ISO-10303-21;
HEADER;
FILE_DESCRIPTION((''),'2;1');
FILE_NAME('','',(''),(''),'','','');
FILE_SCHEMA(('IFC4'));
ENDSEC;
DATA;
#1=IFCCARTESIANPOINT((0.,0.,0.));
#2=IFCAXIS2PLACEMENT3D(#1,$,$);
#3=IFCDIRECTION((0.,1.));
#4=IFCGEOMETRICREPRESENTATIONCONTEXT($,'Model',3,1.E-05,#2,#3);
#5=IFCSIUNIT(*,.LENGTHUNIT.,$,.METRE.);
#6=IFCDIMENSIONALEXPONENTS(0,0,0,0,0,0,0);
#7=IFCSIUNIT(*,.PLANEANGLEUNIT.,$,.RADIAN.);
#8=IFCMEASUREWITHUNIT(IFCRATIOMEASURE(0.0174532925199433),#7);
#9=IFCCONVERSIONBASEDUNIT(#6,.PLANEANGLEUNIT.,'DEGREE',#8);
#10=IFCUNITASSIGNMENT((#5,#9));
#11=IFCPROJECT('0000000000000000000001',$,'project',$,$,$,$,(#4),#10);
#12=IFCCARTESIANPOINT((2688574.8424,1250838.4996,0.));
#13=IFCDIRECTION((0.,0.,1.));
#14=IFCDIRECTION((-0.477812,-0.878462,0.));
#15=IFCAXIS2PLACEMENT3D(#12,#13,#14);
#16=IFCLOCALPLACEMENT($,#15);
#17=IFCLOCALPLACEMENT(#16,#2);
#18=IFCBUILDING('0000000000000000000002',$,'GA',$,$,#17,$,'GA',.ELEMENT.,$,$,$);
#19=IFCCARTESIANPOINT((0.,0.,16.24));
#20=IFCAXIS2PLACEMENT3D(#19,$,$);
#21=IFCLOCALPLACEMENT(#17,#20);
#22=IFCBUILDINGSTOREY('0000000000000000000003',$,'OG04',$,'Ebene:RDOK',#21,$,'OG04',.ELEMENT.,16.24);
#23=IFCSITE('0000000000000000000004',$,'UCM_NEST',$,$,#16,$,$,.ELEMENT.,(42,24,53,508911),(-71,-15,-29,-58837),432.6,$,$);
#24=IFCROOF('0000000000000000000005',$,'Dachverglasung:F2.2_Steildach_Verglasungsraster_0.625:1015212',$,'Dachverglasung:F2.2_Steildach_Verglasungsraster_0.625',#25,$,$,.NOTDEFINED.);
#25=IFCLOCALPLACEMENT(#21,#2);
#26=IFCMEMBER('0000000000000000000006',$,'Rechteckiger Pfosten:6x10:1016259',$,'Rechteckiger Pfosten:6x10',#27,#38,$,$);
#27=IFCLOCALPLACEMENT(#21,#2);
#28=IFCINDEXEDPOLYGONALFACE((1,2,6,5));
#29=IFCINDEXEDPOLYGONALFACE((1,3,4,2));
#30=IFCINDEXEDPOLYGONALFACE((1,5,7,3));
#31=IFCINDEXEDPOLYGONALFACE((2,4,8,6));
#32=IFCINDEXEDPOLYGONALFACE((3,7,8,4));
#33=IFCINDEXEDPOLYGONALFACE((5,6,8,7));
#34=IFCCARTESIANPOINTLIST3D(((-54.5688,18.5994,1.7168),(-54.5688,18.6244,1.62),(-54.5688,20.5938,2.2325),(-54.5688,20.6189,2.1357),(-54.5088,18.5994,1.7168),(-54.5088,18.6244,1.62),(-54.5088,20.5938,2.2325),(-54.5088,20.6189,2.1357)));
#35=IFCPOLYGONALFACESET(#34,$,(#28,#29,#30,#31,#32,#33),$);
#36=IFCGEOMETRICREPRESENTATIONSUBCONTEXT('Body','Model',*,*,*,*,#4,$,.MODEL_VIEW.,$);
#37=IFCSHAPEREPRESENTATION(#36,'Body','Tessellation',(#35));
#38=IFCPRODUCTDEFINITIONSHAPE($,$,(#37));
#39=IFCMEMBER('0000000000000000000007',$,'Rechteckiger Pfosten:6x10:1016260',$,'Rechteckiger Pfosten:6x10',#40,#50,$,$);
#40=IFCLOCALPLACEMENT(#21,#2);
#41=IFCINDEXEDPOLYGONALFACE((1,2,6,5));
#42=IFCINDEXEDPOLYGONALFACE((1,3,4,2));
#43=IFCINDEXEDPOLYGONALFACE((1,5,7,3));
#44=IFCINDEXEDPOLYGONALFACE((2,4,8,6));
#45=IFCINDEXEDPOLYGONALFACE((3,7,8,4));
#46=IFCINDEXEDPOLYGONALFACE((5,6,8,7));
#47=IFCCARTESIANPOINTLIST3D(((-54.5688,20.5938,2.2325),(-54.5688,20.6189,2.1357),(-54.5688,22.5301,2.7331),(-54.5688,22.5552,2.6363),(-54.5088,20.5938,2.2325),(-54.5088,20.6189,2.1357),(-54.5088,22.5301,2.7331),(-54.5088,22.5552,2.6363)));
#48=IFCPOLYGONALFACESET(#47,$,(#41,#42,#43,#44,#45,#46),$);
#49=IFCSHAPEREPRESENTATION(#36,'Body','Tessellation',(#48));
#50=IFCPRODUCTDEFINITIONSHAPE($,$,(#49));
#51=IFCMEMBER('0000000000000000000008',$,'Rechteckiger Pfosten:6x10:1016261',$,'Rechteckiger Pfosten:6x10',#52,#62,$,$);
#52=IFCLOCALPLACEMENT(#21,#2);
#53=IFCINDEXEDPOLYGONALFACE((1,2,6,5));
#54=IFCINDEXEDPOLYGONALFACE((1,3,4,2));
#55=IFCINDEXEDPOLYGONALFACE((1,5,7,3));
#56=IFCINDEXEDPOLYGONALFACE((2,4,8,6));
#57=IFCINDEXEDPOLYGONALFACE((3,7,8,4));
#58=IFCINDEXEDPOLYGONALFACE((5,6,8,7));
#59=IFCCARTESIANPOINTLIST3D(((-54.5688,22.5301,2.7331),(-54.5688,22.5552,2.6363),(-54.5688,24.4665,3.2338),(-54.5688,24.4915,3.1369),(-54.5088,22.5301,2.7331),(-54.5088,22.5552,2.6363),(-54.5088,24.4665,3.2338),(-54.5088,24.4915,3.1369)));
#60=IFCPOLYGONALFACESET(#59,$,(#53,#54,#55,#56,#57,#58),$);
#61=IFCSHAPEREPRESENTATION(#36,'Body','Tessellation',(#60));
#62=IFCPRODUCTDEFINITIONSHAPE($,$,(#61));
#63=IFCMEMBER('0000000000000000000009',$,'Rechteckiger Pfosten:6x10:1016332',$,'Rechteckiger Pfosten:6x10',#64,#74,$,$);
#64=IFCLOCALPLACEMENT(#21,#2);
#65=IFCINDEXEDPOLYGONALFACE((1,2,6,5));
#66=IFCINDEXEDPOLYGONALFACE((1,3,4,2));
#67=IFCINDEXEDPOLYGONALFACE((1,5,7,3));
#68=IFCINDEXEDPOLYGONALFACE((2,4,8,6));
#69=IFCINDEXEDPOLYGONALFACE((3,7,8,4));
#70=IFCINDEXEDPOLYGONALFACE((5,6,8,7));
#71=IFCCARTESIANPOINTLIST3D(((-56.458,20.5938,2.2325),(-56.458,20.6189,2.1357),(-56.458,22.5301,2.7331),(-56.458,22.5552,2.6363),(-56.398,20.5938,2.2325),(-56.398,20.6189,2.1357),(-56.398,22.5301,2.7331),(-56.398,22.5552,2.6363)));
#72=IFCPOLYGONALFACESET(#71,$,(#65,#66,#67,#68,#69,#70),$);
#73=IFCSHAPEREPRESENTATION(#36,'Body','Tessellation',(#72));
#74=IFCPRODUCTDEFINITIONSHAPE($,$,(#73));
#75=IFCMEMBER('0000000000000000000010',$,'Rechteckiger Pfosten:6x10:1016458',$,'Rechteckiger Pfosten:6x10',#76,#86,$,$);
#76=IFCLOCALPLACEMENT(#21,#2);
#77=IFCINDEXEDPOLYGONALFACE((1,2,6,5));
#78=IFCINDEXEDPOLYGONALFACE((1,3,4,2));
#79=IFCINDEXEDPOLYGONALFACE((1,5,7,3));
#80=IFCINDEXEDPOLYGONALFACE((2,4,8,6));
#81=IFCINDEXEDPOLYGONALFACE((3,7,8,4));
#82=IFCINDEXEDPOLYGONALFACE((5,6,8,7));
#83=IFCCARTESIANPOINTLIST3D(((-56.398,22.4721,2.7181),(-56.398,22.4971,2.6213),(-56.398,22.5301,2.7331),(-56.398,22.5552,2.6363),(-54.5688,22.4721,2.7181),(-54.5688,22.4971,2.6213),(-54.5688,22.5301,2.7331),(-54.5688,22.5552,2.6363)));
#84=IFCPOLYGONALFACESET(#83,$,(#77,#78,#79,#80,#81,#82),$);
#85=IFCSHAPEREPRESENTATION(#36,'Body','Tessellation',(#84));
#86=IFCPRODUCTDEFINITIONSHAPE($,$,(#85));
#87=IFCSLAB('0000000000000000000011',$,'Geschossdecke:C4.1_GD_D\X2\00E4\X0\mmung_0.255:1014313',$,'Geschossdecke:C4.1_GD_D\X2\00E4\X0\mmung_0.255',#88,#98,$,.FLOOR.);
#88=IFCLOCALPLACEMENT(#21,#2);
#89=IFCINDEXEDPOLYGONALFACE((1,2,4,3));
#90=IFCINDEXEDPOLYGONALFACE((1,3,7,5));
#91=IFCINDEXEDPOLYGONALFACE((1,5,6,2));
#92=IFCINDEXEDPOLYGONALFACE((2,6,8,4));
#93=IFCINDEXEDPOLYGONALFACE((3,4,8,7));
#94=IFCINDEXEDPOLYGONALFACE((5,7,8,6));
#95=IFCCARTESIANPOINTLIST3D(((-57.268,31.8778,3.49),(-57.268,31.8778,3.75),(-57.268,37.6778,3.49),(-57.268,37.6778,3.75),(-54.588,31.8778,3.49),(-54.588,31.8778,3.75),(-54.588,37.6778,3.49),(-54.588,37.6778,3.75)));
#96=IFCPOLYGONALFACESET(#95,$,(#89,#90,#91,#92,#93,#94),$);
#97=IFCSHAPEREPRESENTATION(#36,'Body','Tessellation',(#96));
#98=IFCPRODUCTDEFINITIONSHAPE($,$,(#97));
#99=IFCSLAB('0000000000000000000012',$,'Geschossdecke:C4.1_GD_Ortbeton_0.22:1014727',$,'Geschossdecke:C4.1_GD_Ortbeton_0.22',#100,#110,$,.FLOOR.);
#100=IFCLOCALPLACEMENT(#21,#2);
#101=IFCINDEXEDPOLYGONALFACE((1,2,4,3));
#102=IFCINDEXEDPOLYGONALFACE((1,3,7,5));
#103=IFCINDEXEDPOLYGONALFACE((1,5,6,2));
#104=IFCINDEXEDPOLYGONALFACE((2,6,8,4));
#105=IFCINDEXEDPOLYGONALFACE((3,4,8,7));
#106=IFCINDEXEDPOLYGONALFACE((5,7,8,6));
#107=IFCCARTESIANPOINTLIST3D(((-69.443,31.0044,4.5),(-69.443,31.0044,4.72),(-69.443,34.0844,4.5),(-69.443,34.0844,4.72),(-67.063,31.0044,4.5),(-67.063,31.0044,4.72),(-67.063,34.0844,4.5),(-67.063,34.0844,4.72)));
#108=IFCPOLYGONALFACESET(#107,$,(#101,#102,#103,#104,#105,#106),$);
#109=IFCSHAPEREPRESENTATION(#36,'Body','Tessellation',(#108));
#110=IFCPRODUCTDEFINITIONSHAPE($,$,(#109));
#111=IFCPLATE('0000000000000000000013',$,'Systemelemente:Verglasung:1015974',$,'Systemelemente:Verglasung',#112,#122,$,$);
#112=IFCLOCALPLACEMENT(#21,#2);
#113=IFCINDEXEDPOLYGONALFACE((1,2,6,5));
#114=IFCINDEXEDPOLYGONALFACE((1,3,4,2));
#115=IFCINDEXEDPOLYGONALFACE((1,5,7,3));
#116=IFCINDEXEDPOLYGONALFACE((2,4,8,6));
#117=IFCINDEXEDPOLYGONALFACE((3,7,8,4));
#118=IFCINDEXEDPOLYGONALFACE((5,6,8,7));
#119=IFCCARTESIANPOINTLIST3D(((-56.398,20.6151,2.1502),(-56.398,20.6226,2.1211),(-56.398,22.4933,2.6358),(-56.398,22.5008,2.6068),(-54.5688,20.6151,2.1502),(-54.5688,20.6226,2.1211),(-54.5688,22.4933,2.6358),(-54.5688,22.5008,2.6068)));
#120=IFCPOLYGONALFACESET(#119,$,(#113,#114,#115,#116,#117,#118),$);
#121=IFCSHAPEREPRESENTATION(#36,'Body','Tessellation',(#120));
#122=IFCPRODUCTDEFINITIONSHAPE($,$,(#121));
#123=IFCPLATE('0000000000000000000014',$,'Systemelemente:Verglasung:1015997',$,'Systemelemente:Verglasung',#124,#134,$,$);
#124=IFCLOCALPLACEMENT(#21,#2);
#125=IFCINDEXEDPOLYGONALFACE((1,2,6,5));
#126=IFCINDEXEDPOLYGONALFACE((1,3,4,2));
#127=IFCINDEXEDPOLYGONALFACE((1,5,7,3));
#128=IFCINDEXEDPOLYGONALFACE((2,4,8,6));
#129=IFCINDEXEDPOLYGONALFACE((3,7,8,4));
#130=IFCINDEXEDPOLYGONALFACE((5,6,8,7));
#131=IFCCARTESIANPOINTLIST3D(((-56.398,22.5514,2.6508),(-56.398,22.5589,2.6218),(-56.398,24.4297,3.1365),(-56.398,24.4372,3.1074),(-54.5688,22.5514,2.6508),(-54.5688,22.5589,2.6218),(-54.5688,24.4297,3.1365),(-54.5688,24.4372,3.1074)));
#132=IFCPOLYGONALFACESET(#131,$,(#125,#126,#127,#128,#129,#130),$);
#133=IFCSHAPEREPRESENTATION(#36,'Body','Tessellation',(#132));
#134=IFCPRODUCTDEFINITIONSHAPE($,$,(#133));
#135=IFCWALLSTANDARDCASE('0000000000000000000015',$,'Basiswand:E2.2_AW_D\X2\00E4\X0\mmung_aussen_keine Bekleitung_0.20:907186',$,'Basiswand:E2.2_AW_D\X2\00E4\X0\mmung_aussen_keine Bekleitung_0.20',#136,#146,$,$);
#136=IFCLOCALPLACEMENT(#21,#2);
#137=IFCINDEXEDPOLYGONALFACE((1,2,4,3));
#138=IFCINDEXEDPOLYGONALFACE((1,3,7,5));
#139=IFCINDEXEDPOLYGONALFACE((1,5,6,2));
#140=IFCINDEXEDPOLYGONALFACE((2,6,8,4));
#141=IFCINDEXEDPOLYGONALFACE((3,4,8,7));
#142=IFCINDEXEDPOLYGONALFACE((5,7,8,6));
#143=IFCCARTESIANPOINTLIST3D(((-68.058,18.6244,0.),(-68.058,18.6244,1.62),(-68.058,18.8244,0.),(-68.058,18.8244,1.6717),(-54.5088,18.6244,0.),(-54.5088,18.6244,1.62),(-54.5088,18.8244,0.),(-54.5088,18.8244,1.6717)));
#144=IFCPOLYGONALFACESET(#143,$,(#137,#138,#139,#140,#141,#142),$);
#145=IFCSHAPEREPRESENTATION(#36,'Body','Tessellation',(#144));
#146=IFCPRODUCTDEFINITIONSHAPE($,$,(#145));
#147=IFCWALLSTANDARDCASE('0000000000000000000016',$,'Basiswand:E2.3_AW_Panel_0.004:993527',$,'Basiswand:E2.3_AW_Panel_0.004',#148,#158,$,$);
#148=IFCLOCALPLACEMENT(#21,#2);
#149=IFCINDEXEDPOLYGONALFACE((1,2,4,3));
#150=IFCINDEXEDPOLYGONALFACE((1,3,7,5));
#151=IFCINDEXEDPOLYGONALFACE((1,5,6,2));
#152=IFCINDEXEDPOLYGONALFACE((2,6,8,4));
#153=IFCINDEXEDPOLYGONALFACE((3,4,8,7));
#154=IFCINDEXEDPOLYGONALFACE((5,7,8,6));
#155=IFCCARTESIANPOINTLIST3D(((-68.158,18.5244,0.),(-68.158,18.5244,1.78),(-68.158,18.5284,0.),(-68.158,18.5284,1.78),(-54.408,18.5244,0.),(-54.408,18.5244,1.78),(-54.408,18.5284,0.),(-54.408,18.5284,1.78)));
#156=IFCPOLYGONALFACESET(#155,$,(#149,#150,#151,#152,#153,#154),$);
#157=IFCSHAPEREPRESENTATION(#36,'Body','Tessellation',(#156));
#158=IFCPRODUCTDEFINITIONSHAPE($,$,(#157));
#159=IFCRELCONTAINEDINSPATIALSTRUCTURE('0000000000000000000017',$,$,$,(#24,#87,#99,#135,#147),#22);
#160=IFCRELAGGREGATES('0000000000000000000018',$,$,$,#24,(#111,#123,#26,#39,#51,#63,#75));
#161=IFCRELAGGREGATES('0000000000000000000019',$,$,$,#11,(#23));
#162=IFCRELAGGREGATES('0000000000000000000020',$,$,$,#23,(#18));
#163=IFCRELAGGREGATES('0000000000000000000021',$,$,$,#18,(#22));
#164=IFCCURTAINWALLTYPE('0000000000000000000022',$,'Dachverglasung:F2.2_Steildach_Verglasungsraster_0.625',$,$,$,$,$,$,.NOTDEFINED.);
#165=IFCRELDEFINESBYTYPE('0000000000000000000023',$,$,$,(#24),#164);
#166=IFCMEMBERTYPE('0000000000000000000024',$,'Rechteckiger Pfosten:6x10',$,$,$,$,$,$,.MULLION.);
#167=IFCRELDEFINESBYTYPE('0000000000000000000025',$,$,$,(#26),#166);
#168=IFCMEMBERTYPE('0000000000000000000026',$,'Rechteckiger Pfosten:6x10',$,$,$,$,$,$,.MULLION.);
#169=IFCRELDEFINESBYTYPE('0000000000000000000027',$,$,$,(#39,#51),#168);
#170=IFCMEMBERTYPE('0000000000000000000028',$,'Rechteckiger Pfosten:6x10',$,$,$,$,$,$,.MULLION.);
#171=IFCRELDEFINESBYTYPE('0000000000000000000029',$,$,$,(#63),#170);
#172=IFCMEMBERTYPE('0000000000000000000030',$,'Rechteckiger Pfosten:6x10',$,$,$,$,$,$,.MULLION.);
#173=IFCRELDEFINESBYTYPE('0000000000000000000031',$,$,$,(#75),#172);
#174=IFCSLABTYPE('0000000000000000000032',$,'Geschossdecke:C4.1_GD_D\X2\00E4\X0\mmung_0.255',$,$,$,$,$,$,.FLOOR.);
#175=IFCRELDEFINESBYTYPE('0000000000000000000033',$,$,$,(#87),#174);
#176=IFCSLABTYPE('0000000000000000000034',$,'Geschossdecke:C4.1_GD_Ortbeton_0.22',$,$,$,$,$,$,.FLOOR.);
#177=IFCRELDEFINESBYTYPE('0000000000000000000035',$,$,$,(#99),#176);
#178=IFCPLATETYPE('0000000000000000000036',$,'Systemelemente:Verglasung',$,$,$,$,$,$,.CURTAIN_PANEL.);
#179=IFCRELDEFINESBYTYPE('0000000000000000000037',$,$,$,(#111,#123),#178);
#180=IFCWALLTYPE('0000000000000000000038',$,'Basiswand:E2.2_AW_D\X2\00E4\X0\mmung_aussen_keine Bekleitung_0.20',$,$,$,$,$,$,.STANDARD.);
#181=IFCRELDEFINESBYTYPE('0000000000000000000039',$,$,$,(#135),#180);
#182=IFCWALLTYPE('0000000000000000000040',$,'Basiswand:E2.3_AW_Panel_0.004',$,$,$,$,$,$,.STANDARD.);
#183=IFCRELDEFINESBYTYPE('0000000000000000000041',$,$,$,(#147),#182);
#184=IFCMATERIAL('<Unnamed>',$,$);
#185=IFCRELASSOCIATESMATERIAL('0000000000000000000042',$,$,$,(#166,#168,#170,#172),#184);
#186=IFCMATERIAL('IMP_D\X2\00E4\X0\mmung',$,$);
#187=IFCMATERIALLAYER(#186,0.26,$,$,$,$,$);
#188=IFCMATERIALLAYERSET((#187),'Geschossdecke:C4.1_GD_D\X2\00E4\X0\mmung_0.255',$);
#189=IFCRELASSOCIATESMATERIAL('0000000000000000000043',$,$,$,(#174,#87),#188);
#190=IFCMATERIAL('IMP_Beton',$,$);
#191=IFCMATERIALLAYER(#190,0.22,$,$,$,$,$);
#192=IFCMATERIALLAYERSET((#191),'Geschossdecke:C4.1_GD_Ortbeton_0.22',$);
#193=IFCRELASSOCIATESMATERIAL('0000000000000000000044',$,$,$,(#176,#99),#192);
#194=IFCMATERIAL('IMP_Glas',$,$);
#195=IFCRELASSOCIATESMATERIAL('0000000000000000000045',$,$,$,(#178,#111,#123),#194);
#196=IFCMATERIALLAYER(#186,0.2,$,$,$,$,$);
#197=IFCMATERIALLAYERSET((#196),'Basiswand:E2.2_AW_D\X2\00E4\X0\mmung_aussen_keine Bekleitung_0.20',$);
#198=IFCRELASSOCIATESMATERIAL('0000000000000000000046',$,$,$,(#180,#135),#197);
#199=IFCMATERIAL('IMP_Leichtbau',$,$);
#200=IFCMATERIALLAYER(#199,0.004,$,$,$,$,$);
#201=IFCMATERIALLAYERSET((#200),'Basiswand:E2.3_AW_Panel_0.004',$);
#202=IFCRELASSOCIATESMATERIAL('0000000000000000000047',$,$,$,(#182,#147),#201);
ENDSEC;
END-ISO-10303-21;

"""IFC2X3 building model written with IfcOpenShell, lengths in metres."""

from ifc_helpers import new_model, entity, si_unit, converted_unit, direction, frame, frame_2d, origin, origin_2d_with_axis, place, context, subcontext, project, spatial, polyline, rectangle, extrude, clip, bounded_halfspace, source, transform, mapped, material, layer, layer_set, layer_usage, type_object, type_shapes, element, aggregate, save


model = new_model("IFC2X3")

# Units and contexts
model_context = context("Model", 3, precision=1e-05, world=origin(), true_north=direction((0.0, 1.0)))
body_context = subcontext(model_context, "Body", "Model", "MODEL_VIEW")
ifc_project = project(units=[si_unit("LENGTHUNIT", "METRE"), converted_unit("PLANEANGLEUNIT", "DEGREE", entity("IfcRatioMeasure", 0.0174532925199433), si_unit("PLANEANGLEUNIT", "RADIAN"), dimensions=[0, 0, 0, 0, 0, 0, 0])], contexts=[model_context])

# Site, building, storey
site_placement = place(None, frame((2688574.8424, 1250838.4996, 0.0), z_axis=(0.0, 0.0, 1.0), x_axis=(-0.477812, -0.878462, 0.0)))
site = spatial("IfcSite", under=ifc_project, at=site_placement, Name="UCM_NEST", CompositionType="ELEMENT", RefLatitude=(42, 24, 53, 508911), RefLongitude=(-71, -15, -29, -58837), RefElevation=432.6)
building_placement = place(site_placement, origin())
building = spatial("IfcBuilding", under=site, at=building_placement, Name="GA", LongName="GA", CompositionType="ELEMENT")
storey_placement = place(building_placement, frame((0.0, 0.0, 16.24)))
storey = spatial("IfcBuildingStorey", under=building, at=storey_placement, Name="OG04", ObjectType="Ebene:RDOK", LongName="OG04", CompositionType="ELEMENT", Elevation=16.24)

# Roof, members
curtain_wall_type = type_object("IfcCurtainWallType", Name="Dachverglasung:F2.2_Steildach_Verglasungsraster_0.625", PredefinedType="NOTDEFINED")
roof_placement = place(storey_placement, frame((0.0, 0.0, -16.24)))
roof = element("IfcRoof", 1, at=roof_placement, inside=storey, type_object=curtain_wall_type, Name="Dachverglasung:F2.2_Steildach_Verglasungsraster_0.625:1015212", ObjectType="Dachverglasung:F2.2_Steildach_Verglasungsraster_0.625", ShapeType="NOTDEFINED")
ifc_material_1 = material(Name="<Unnamed>")
member_type_1 = type_object("IfcMemberType", Name="Rechteckiger Pfosten:6x10", PredefinedType="MULLION", material=ifc_material_1)
shared_shape_1 = source(origin(), body_context, "Body", "SweptSolid", [
    extrude(rectangle(XDim=0.1, YDim=0.06, at=frame_2d((0.0, 0.0), x_axis=(1.0, 0.0))), frame((-0.03, -0.05, -2.06), z_axis=(0.0, 0.0, 1.0), x_axis=(0.0, -1.0, 0.0)), (0.0, 0.0, 1.0), 2.06),
])
type_shapes(member_type_1, [shared_shape_1])
member_1_placement = place(roof_placement, frame((-54.5088, 20.6189, 18.3757), z_axis=(0.0, 0.968163, 0.250322), x_axis=(1.0, 0.0, 0.0)))
member_1 = element("IfcMember", 2, at=member_1_placement, type_object=member_type_1, Name="Rechteckiger Pfosten:6x10:1016259", ObjectType="Rechteckiger Pfosten:6x10", context=body_context, shape_type="MappedRepresentation", body=[
    mapped(shared_shape_1, transform((0.0, 0.0, 0.0), scale=1.0)),
])
member_type_2 = type_object("IfcMemberType", Name="Rechteckiger Pfosten:6x10", PredefinedType="MULLION", material=ifc_material_1)
shared_shape_2 = source(origin(), body_context, "Body", "SweptSolid", [
    extrude(rectangle(XDim=0.1, YDim=0.06, at=origin_2d_with_axis()), frame((-0.03, -0.05, -2.0), z_axis=(0.0, 0.0, 1.0), x_axis=(0.0, -1.0, 0.0)), (0.0, 0.0, 1.0), 2.0),
])
type_shapes(member_type_2, [shared_shape_2])
member_2_placement = place(roof_placement, frame((-54.5088, 22.5552, 18.8763), z_axis=(0.0, 0.968163, 0.250322), x_axis=(1.0, 0.0, 0.0)))
member_2 = element("IfcMember", 3, at=member_2_placement, type_object=member_type_2, Name="Rechteckiger Pfosten:6x10:1016260", ObjectType="Rechteckiger Pfosten:6x10", context=body_context, shape_type="MappedRepresentation", body=[
    mapped(shared_shape_2, transform((0.0, 0.0, 0.0), scale=1.0)),
])
member_3_placement = place(roof_placement, frame((-54.5088, 24.4915, 19.3769), z_axis=(0.0, 0.968163, 0.250322), x_axis=(1.0, 0.0, 0.0)))
member_3 = element("IfcMember", 4, at=member_3_placement, type_object=member_type_2, Name="Rechteckiger Pfosten:6x10:1016261", ObjectType="Rechteckiger Pfosten:6x10", context=body_context, shape_type="MappedRepresentation", body=[
    mapped(shared_shape_2, transform((0.0, 0.0, 0.0), scale=1.0)),
])
member_type_3 = type_object("IfcMemberType", Name="Rechteckiger Pfosten:6x10", PredefinedType="MULLION", material=ifc_material_1)
shared_shape_3 = source(origin(), body_context, "Body", "SweptSolid", [
    extrude(rectangle(XDim=0.1, YDim=0.06, at=origin_2d_with_axis()), frame((-0.03, -0.05, -2.0), z_axis=(0.0, 0.0, 1.0), x_axis=(0.0, -1.0, 0.0)), (0.0, 0.0, 1.0), 2.0),
])
type_shapes(member_type_3, [shared_shape_3])
member_4_placement = place(roof_placement, frame((-56.398, 22.5552, 18.8763), z_axis=(0.0, 0.968163, 0.250322), x_axis=(1.0, 0.0, 0.0)))
member_4 = element("IfcMember", 5, at=member_4_placement, type_object=member_type_3, Name="Rechteckiger Pfosten:6x10:1016332", ObjectType="Rechteckiger Pfosten:6x10", context=body_context, shape_type="MappedRepresentation", body=[
    mapped(shared_shape_3, transform((0.0, 0.0, 0.0), scale=1.0)),
])
member_type_4 = type_object("IfcMemberType", Name="Rechteckiger Pfosten:6x10", PredefinedType="MULLION", material=ifc_material_1)
shared_shape_4 = source(origin(), body_context, "Body", "SweptSolid", [
    extrude(rectangle(XDim=0.1, YDim=0.06, at=origin_2d_with_axis()), frame((-0.03, -0.05, -1.8292), z_axis=(0.0, 0.0, 1.0), x_axis=(0.0, -1.0, 0.0)), (0.0, 0.0, 1.0), 1.8292),
])
type_shapes(member_type_4, [shared_shape_4])
member_5_placement = place(roof_placement, frame((-56.398, 22.5552, 18.8763), z_axis=(-1.0, 0.0, 0.0), x_axis=(0.0, 0.968163, 0.250322)))
member_5 = element("IfcMember", 6, at=member_5_placement, type_object=member_type_4, Name="Rechteckiger Pfosten:6x10:1016458", ObjectType="Rechteckiger Pfosten:6x10", context=body_context, shape_type="MappedRepresentation", body=[
    mapped(shared_shape_4, transform((0.0, 0.0, 0.0), scale=1.0)),
])

# Slabs
ifc_material_2 = material(Name="IMP_Beton")
ifc_material_3 = material(Name="IMP_Dämmung")
ifc_layer_1 = layer(ifc_material_3, 0.26)
ifc_layer_set_1 = layer_set([ifc_layer_1], Name="Geschossdecke:C4.1_GD_Dämmung_0.255")
ifc_layer_usage_1 = layer_usage(ifc_layer_set_1, "AXIS3", "POSITIVE", 0.0)
slab_type_1 = type_object("IfcSlabType", Name="Geschossdecke:C4.1_GD_Dämmung_0.255", PredefinedType="FLOOR", material=ifc_layer_set_1)
slab_1_placement = place(storey_placement, origin())
element("IfcSlab", 7, at=slab_1_placement, inside=storey, type_object=slab_type_1, material=ifc_layer_usage_1, Name="Geschossdecke:C4.1_GD_Dämmung_0.255:1014313", ObjectType="Geschossdecke:C4.1_GD_Dämmung_0.255", PredefinedType="FLOOR", context=body_context, shape_type="SweptSolid", body=[
    extrude(rectangle(XDim=5.8, YDim=2.68, at=frame_2d((0.0, 0.0), x_axis=(1.0, 0.0))), frame((-55.928, 34.7778, 3.75), z_axis=(0.0, 0.0, -1.0), x_axis=(0.0, 1.0, 0.0)), (0.0, 0.0, 1.0), 0.26),
])
ifc_layer_2 = layer(ifc_material_2, 0.22)
ifc_layer_set_2 = layer_set([ifc_layer_2], Name="Geschossdecke:C4.1_GD_Ortbeton_0.22")
ifc_layer_usage_2 = layer_usage(ifc_layer_set_2, "AXIS3", "POSITIVE", 0.0)
slab_type_2 = type_object("IfcSlabType", Name="Geschossdecke:C4.1_GD_Ortbeton_0.22", PredefinedType="FLOOR", material=ifc_layer_set_2)
slab_2_placement = place(storey_placement, origin())
element("IfcSlab", 8, at=slab_2_placement, inside=storey, type_object=slab_type_2, material=ifc_layer_usage_2, Name="Geschossdecke:C4.1_GD_Ortbeton_0.22:1014727", ObjectType="Geschossdecke:C4.1_GD_Ortbeton_0.22", PredefinedType="FLOOR", context=body_context, shape_type="SweptSolid", body=[
    extrude(rectangle(XDim=3.08, YDim=2.38, at=origin_2d_with_axis()), frame((-68.253, 32.5444, 4.72), z_axis=(0.0, 0.0, -1.0), x_axis=(0.0, 1.0, 0.0)), (0.0, 0.0, 1.0), 0.22),
])

# Plates
ifc_material_4 = material(Name="IMP_Glas")
plate_type = type_object("IfcPlateType", Name="Systemelemente:Verglasung", PredefinedType="CURTAIN_PANEL", material=ifc_material_4)
shared_shape_5 = source(origin(), body_context, "Body", "SweptSolid", [
    extrude(rectangle(XDim=0.03, YDim=1.8292, at=origin_2d_with_axis()), frame((0.0, 0.0, 0.0), z_axis=(0.0, 0.0, 1.0), x_axis=(0.0, 1.0, 0.0)), (0.0, 0.0, 1.0), 1.94),
])
type_shapes(plate_type, [shared_shape_5])
plate_1_placement = place(roof_placement, frame((-55.4834, 20.6189, 18.3757), z_axis=(0.0, 0.968163, 0.250322), x_axis=(1.0, 0.0, 0.0)))
plate_1 = element("IfcPlate", 9, at=plate_1_placement, type_object=plate_type, material=ifc_material_4, Name="Systemelemente:Verglasung:1015974", ObjectType="Systemelemente:Verglasung", context=body_context, shape_type="MappedRepresentation", body=[
    mapped(shared_shape_5, transform((0.0, 0.0, 0.0), scale=1.0)),
])
plate_2_placement = place(roof_placement, frame((-55.4834, 22.5552, 18.8763), z_axis=(0.0, 0.968163, 0.250322), x_axis=(1.0, 0.0, 0.0)))
plate_2 = element("IfcPlate", 10, at=plate_2_placement, type_object=plate_type, material=ifc_material_4, Name="Systemelemente:Verglasung:1015997", ObjectType="Systemelemente:Verglasung", context=body_context, shape_type="MappedRepresentation", body=[
    mapped(shared_shape_5, transform((0.0, 0.0, 0.0), scale=1.0)),
])
aggregate(roof, [plate_1, plate_2, member_1, member_2, member_3, member_4, member_5])

# Walls
ifc_layer_3 = layer(ifc_material_3, 0.2)
ifc_layer_set_3 = layer_set([ifc_layer_3], Name="Basiswand:E2.2_AW_Dämmung_aussen_keine Bekleitung_0.20")
ifc_layer_usage_3 = layer_usage(ifc_layer_set_3, "AXIS2", "NEGATIVE", 0.1)
wall_type_1 = type_object("IfcWallType", Name="Basiswand:E2.2_AW_Dämmung_aussen_keine Bekleitung_0.20", PredefinedType="STANDARD", material=ifc_layer_set_3)
wall_1_placement = place(storey_placement, frame((-54.5088, 18.7244, 0.0), z_axis=(0.0, 0.0, 1.0), x_axis=(-1.0, 0.0, 0.0)))
element("IfcWallStandardCase", 11, at=wall_1_placement, inside=storey, type_object=wall_type_1, material=ifc_layer_usage_3, Name="Basiswand:E2.2_AW_Dämmung_aussen_keine Bekleitung_0.20:907186", ObjectType="Basiswand:E2.2_AW_Dämmung_aussen_keine Bekleitung_0.20", context=body_context, shape_type="Clipping", body=[
    clip(extrude(rectangle(XDim=13.5492, YDim=0.2, at=frame_2d((6.7746, 0.0), x_axis=(-1.0, 0.0))), origin(), (0.0, 0.0, 1.0), 1.6717), bounded_halfspace(frame((0.0, -0.1, 1.6717), z_axis=(0.0, 0.250322, 0.968163), x_axis=(-1.0, 0.0, 0.0)), False, frame((0.0, -0.1, 1.6717)), polyline([(0.0, 0.0), (13.5492, 0.0), (13.5492, 0.2), (0.0, 0.2), (0.0, 0.0)]))),
])
ifc_material_5 = material(Name="IMP_Leichtbau")
ifc_layer_4 = layer(ifc_material_5, 0.004)
ifc_layer_set_4 = layer_set([ifc_layer_4], Name="Basiswand:E2.3_AW_Panel_0.004")
ifc_layer_usage_4 = layer_usage(ifc_layer_set_4, "AXIS2", "NEGATIVE", 0.002)
wall_type_2 = type_object("IfcWallType", Name="Basiswand:E2.3_AW_Panel_0.004", PredefinedType="STANDARD", material=ifc_layer_set_4)
wall_2_placement = place(storey_placement, frame((-54.408, 18.5264, 0.0), z_axis=(0.0, 0.0, 1.0), x_axis=(-1.0, 0.0, 0.0)))
element("IfcWallStandardCase", 12, at=wall_2_placement, inside=storey, type_object=wall_type_2, material=ifc_layer_usage_4, Name="Basiswand:E2.3_AW_Panel_0.004:993527", ObjectType="Basiswand:E2.3_AW_Panel_0.004", context=body_context, shape_type="SweptSolid", body=[
    extrude(rectangle(XDim=13.75, YDim=0.004, at=frame_2d((6.875, 0.0), x_axis=(-1.0, 0.0))), origin(), (0.0, 0.0, 1.0), 1.78),
])

save(model, "model.ifc")
